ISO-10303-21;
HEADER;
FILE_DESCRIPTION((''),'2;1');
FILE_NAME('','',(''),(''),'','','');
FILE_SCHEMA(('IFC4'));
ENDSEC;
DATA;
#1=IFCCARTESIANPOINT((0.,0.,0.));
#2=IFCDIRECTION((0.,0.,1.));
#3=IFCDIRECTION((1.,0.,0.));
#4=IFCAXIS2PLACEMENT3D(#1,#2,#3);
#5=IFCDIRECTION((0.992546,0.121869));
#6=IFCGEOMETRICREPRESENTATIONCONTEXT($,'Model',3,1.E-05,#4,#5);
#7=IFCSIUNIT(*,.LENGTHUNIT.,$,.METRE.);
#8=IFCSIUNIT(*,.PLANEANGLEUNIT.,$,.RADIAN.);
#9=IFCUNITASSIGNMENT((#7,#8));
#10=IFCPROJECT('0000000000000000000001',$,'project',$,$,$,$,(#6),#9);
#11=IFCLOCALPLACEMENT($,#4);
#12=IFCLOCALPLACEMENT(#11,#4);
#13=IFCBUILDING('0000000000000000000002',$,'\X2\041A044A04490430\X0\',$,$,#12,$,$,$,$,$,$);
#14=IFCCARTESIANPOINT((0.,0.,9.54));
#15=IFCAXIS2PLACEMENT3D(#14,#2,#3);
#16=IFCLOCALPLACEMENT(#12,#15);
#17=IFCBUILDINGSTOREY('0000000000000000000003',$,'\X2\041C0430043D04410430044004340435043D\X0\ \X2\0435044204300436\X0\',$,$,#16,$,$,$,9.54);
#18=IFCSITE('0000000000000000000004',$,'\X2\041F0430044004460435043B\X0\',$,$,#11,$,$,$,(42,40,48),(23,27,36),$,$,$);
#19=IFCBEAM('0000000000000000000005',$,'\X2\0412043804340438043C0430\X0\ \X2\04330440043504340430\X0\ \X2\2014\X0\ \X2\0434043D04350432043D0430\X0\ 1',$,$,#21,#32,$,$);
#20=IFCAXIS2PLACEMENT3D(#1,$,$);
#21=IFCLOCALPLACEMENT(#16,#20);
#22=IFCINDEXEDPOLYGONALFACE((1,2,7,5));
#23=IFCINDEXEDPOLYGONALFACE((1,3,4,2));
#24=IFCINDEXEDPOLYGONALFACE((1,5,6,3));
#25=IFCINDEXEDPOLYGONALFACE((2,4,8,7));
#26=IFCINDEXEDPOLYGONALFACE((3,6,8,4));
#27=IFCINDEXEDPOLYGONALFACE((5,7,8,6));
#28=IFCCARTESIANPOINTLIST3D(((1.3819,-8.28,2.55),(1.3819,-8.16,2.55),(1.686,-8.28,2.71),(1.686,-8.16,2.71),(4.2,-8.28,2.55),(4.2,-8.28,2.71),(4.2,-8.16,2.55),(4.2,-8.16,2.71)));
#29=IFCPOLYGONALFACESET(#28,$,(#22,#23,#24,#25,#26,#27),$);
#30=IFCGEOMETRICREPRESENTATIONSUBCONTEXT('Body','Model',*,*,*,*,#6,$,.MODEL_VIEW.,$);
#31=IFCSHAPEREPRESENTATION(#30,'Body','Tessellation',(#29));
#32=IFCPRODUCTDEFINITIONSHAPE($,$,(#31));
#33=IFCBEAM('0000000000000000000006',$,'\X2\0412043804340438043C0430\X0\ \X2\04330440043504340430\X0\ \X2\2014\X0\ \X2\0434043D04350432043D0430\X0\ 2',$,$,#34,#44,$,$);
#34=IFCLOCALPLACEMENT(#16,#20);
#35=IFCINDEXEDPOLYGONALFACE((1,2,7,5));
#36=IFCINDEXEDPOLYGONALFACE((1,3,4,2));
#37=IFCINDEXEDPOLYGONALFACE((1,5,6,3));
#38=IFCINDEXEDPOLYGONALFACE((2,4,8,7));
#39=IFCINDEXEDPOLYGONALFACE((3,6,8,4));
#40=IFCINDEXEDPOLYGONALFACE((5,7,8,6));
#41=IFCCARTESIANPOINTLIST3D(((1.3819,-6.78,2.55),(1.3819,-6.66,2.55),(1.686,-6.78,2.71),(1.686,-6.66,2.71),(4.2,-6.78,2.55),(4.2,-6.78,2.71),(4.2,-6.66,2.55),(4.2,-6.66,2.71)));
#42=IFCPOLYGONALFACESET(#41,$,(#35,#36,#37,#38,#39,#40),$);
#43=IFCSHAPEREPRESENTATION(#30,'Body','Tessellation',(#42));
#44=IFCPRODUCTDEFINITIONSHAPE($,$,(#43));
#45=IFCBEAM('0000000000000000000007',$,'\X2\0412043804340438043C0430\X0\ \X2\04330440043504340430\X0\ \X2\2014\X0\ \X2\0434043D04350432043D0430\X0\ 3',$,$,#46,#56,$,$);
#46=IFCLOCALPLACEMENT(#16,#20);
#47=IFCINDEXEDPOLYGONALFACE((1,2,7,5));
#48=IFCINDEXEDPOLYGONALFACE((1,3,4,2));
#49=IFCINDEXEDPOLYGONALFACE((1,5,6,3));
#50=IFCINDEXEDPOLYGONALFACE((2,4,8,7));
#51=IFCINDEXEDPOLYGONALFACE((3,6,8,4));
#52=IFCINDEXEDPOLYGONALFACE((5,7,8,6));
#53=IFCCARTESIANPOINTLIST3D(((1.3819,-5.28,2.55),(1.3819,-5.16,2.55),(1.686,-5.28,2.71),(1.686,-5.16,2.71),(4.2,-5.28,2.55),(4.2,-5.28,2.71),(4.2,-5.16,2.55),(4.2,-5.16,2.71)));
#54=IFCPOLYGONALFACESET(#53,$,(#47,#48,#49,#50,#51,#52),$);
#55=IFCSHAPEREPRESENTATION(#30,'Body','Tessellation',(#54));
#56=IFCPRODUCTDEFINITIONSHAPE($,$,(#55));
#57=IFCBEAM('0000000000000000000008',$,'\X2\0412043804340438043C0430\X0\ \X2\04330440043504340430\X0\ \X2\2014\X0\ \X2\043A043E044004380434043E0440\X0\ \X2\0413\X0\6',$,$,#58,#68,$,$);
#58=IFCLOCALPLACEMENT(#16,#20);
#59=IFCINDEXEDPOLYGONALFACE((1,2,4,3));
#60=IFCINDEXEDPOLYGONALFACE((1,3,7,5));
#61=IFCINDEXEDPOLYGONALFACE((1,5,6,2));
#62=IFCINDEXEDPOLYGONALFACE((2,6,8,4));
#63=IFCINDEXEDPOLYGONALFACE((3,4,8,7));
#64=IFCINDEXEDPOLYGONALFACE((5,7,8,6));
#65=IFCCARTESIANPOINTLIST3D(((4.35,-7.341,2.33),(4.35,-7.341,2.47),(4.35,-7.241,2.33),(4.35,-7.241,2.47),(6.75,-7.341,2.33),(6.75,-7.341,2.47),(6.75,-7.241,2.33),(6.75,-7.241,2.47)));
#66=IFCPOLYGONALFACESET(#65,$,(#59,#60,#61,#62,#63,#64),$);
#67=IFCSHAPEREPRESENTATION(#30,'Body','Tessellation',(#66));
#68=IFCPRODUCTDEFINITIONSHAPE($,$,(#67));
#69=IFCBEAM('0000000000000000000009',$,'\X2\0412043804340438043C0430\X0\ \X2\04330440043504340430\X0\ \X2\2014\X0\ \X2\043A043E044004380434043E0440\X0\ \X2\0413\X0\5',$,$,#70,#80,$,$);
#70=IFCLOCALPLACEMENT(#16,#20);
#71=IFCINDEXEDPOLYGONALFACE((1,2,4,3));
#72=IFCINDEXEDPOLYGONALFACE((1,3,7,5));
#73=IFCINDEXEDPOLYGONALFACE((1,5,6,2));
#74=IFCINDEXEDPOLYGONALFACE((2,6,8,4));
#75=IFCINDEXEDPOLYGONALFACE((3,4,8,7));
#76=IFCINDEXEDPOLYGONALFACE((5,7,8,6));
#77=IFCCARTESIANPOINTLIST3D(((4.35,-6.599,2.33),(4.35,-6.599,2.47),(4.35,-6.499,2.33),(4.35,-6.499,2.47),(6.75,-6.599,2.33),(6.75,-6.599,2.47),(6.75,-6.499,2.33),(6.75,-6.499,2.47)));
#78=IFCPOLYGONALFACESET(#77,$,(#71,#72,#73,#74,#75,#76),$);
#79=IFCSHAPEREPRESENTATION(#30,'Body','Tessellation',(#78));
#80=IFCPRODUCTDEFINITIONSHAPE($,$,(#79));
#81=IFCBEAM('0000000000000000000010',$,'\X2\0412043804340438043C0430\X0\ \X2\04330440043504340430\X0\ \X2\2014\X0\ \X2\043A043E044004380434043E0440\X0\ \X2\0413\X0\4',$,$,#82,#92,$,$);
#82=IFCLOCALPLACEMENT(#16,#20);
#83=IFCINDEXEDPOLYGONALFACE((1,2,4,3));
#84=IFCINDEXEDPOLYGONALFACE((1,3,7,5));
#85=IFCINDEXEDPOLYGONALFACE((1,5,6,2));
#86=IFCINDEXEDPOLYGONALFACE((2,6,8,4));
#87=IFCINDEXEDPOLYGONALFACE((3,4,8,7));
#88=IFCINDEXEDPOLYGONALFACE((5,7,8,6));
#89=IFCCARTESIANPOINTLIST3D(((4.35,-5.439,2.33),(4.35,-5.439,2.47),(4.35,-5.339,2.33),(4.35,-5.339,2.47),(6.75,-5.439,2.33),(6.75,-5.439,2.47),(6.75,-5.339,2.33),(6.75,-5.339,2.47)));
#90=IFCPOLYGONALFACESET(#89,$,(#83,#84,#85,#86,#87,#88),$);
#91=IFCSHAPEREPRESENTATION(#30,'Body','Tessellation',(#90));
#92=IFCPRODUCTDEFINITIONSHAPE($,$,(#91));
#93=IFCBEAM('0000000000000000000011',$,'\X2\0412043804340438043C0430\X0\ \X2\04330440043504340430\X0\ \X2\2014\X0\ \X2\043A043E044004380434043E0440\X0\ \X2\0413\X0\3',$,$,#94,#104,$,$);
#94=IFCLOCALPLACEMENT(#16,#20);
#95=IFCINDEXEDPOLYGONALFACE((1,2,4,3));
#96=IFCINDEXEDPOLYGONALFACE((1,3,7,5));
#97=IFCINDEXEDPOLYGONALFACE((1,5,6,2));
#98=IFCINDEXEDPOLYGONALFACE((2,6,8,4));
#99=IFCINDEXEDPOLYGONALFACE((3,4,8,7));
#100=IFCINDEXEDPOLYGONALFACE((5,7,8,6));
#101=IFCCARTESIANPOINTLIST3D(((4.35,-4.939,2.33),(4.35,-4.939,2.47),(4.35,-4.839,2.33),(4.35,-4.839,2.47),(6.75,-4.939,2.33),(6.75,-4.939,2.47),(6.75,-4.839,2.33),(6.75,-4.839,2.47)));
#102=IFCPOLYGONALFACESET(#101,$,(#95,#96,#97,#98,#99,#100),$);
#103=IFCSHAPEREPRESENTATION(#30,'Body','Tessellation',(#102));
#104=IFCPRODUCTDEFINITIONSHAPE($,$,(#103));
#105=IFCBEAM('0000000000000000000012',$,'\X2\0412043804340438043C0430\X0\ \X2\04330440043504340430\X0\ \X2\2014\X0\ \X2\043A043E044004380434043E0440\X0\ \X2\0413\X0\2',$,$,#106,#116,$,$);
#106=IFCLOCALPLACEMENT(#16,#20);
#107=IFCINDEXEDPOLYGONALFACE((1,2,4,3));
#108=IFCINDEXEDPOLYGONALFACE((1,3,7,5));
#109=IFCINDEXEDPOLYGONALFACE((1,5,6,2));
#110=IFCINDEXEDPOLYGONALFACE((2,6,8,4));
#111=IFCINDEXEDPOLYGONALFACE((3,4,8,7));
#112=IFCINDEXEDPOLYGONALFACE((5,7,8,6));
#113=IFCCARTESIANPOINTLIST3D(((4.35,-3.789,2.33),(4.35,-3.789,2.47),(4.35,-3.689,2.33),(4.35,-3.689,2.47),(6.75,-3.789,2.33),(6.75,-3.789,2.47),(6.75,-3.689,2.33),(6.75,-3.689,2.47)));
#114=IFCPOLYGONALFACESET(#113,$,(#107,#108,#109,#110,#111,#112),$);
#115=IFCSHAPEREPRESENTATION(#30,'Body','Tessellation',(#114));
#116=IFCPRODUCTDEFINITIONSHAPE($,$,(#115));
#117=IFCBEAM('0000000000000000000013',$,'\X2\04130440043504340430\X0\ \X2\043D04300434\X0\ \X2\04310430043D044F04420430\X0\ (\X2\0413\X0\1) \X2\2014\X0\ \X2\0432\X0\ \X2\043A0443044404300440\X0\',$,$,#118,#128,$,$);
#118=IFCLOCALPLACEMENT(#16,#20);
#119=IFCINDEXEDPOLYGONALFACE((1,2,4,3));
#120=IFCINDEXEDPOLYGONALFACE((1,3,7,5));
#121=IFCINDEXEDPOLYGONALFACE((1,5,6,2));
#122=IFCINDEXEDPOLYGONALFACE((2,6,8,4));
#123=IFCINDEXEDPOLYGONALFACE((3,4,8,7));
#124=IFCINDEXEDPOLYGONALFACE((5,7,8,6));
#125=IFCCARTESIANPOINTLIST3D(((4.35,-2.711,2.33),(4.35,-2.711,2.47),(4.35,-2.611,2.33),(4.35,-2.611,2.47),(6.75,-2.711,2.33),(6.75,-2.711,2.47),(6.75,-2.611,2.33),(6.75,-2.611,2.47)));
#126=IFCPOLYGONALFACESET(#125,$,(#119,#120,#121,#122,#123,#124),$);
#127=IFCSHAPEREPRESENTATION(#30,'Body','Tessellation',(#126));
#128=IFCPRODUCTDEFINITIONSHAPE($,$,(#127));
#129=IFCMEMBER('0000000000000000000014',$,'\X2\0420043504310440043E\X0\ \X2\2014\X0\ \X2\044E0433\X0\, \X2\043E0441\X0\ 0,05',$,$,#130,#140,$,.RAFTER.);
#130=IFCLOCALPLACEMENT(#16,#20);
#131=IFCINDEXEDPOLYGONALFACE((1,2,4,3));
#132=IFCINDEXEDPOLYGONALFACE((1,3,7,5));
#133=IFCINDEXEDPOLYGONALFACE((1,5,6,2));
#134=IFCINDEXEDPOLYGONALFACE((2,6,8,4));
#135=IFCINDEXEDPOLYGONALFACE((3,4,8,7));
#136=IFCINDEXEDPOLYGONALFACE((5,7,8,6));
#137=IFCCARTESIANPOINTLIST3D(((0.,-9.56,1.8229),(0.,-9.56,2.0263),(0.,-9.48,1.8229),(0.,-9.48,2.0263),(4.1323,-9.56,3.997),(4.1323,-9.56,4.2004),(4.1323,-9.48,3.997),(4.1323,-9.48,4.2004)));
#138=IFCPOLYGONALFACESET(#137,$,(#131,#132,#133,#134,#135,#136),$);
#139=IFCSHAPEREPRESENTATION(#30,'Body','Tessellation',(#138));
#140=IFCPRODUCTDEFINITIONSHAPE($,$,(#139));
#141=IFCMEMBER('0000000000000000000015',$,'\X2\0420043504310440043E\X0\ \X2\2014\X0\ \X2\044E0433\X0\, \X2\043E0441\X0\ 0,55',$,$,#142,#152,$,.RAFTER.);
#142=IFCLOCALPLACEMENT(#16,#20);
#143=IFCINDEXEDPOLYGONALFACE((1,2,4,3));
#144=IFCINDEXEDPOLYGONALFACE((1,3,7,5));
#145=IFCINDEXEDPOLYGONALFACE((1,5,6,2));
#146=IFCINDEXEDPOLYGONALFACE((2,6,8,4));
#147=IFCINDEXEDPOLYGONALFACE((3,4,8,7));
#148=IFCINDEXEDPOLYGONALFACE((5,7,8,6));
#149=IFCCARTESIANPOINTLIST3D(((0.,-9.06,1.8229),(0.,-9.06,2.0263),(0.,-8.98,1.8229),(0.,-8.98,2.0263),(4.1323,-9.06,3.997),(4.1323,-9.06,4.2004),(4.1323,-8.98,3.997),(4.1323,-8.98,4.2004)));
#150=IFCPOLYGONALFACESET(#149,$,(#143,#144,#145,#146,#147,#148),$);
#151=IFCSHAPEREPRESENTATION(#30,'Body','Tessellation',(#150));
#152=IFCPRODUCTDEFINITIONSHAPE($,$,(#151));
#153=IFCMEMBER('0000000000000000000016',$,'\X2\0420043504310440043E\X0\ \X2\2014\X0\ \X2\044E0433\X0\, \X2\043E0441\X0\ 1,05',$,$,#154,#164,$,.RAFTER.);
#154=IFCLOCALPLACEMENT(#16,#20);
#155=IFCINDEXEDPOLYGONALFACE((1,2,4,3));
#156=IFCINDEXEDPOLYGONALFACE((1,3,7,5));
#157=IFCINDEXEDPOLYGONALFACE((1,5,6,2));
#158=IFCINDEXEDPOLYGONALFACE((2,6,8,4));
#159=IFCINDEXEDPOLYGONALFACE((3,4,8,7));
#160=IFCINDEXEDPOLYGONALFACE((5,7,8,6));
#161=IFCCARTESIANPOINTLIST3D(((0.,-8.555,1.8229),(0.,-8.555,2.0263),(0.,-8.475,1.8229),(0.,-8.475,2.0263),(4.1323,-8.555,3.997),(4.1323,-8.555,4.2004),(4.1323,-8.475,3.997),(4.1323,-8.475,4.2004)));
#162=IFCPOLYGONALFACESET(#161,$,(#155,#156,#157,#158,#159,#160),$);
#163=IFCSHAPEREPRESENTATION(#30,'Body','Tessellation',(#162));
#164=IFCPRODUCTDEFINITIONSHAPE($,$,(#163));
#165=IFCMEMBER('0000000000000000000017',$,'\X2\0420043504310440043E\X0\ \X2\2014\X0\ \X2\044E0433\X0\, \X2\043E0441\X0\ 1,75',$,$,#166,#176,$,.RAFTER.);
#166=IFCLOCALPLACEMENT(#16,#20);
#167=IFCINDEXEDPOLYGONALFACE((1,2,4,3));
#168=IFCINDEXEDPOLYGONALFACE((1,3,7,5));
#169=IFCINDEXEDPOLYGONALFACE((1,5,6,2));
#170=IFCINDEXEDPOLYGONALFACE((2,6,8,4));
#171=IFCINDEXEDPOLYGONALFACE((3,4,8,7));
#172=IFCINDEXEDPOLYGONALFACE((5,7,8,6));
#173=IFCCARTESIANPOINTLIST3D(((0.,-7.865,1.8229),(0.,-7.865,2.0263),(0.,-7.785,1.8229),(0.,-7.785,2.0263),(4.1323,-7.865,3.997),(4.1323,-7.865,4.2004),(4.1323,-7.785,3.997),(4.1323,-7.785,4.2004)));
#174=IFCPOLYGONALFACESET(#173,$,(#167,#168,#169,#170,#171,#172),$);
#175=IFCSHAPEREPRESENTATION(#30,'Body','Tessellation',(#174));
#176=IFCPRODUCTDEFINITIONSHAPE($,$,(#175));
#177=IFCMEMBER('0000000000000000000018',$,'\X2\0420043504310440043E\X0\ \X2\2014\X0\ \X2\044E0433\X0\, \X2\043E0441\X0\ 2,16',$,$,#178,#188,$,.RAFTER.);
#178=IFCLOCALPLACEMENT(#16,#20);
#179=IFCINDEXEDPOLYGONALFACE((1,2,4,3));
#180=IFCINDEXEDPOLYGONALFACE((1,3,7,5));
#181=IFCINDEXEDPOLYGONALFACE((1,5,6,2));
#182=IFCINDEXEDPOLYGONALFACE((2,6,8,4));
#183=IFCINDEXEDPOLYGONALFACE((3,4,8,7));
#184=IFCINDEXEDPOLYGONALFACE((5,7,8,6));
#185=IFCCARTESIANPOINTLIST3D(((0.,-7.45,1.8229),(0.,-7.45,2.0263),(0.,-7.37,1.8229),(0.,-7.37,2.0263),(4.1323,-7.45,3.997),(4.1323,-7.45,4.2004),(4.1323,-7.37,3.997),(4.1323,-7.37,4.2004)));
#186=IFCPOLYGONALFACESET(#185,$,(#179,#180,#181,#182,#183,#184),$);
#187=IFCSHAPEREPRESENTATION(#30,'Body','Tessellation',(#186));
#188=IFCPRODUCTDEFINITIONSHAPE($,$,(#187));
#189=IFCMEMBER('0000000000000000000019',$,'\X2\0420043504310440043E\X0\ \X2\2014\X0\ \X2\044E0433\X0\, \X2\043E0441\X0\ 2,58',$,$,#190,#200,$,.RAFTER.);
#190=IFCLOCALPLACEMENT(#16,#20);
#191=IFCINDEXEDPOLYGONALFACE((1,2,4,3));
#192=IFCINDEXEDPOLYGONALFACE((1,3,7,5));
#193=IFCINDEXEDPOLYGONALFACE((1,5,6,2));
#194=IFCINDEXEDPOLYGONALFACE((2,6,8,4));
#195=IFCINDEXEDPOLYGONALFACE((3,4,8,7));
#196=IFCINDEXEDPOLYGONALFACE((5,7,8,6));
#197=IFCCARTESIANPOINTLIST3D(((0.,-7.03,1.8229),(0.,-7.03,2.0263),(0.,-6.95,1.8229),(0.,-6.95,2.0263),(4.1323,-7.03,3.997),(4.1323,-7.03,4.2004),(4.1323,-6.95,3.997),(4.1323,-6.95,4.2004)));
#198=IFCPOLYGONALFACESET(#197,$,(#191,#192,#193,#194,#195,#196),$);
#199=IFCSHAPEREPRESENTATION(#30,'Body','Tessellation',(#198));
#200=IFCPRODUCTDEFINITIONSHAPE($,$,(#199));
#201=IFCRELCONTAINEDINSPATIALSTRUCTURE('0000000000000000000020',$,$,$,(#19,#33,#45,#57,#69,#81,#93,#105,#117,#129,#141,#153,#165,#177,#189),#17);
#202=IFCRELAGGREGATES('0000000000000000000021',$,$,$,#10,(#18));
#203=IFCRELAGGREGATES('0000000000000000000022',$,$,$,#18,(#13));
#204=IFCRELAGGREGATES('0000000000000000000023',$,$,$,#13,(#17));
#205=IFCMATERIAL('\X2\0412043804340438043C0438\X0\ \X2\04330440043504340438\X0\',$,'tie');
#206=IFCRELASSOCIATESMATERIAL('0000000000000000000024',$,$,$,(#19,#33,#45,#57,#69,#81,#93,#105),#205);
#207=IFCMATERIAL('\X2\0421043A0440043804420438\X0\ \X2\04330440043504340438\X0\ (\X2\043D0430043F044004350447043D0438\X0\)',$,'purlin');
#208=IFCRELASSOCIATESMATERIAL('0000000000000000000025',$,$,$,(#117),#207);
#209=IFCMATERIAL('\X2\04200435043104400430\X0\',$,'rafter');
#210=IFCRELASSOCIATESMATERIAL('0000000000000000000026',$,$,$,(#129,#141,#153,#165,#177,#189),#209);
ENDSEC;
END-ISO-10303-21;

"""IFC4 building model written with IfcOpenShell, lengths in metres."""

from ifc_helpers import new_model, si_unit, direction, frame, origin_with_axes, place, context, subcontext, project, spatial, polyline, outline, extrude, material, element, save


model = new_model("IFC4")

# Units and contexts
model_context = context("Model", 3, precision=1e-05, world=origin_with_axes(), true_north=direction((0.992546, 0.121869)))
body_context = subcontext(model_context, "Body", "Model", "MODEL_VIEW")
ifc_project = project(units=[si_unit("LENGTHUNIT", "METRE"), si_unit("PLANEANGLEUNIT", "RADIAN")], contexts=[model_context])

# Site, building, storey
site_placement = place(None, origin_with_axes())
site = spatial("IfcSite", under=ifc_project, at=site_placement, Name="Парцел", RefLatitude=(42, 40, 48), RefLongitude=(23, 27, 36))
building_placement = place(site_placement, origin_with_axes())
building = spatial("IfcBuilding", under=site, at=building_placement, Name="Къща")
storey_placement = place(building_placement, frame((0.0, 0.0, 9.54), z_axis=(0.0, 0.0, 1.0), x_axis=(1.0, 0.0, 0.0)))
storey = spatial("IfcBuildingStorey", under=building, at=storey_placement, Name="Мансарден етаж", Elevation=9.54)

# Beams
ifc_material_1 = material(Name="Видими греди", Category="tie")
beam_1_placement = place(storey_placement, origin_with_axes())
element("IfcBeam", 1, at=beam_1_placement, inside=storey, material=ifc_material_1, Name="Видима греда — дневна 1", context=body_context, shape_type="SweptSolid", body=[
    extrude(outline(polyline([(1.3819, -2.55), (4.2, -2.55), (4.2, -2.71), (1.686, -2.71), (1.3819, -2.55)])), frame((0.0, -8.28, 0.0), z_axis=(0.0, 1.0, 0.0), x_axis=(1.0, 0.0, 0.0)), (0.0, 0.0, 1.0), 0.12),
])
beam_2_placement = place(storey_placement, origin_with_axes())
element("IfcBeam", 2, at=beam_2_placement, inside=storey, material=ifc_material_1, Name="Видима греда — дневна 2", context=body_context, shape_type="SweptSolid", body=[
    extrude(outline(polyline([(1.3819, -2.55), (4.2, -2.55), (4.2, -2.71), (1.686, -2.71), (1.3819, -2.55)])), frame((0.0, -6.78, 0.0), z_axis=(0.0, 1.0, 0.0), x_axis=(1.0, 0.0, 0.0)), (0.0, 0.0, 1.0), 0.12),
])
beam_3_placement = place(storey_placement, origin_with_axes())
element("IfcBeam", 3, at=beam_3_placement, inside=storey, material=ifc_material_1, Name="Видима греда — дневна 3", context=body_context, shape_type="SweptSolid", body=[
    extrude(outline(polyline([(1.3819, -2.55), (4.2, -2.55), (4.2, -2.71), (1.686, -2.71), (1.3819, -2.55)])), frame((0.0, -5.28, 0.0), z_axis=(0.0, 1.0, 0.0), x_axis=(1.0, 0.0, 0.0)), (0.0, 0.0, 1.0), 0.12),
])
beam_4_placement = place(storey_placement, origin_with_axes())
element("IfcBeam", 4, at=beam_4_placement, inside=storey, material=ifc_material_1, Name="Видима греда — коридор Г6", context=body_context, shape_type="SweptSolid", body=[
    extrude(outline(polyline([(4.35, -2.33), (6.75, -2.33), (6.75, -2.47), (4.35, -2.47), (4.35, -2.33)])), frame((0.0, -7.341, 0.0), z_axis=(0.0, 1.0, 0.0), x_axis=(1.0, 0.0, 0.0)), (0.0, 0.0, 1.0), 0.1),
])
beam_5_placement = place(storey_placement, origin_with_axes())
element("IfcBeam", 5, at=beam_5_placement, inside=storey, material=ifc_material_1, Name="Видима греда — коридор Г5", context=body_context, shape_type="SweptSolid", body=[
    extrude(outline(polyline([(4.35, -2.33), (6.75, -2.33), (6.75, -2.47), (4.35, -2.47), (4.35, -2.33)])), frame((0.0, -6.599, 0.0), z_axis=(0.0, 1.0, 0.0), x_axis=(1.0, 0.0, 0.0)), (0.0, 0.0, 1.0), 0.1),
])
beam_6_placement = place(storey_placement, origin_with_axes())
element("IfcBeam", 6, at=beam_6_placement, inside=storey, material=ifc_material_1, Name="Видима греда — коридор Г4", context=body_context, shape_type="SweptSolid", body=[
    extrude(outline(polyline([(4.35, -2.33), (6.75, -2.33), (6.75, -2.47), (4.35, -2.47), (4.35, -2.33)])), frame((0.0, -5.439, 0.0), z_axis=(0.0, 1.0, 0.0), x_axis=(1.0, 0.0, 0.0)), (0.0, 0.0, 1.0), 0.1),
])
beam_7_placement = place(storey_placement, origin_with_axes())
element("IfcBeam", 7, at=beam_7_placement, inside=storey, material=ifc_material_1, Name="Видима греда — коридор Г3", context=body_context, shape_type="SweptSolid", body=[
    extrude(outline(polyline([(4.35, -2.33), (6.75, -2.33), (6.75, -2.47), (4.35, -2.47), (4.35, -2.33)])), frame((0.0, -4.939, 0.0), z_axis=(0.0, 1.0, 0.0), x_axis=(1.0, 0.0, 0.0)), (0.0, 0.0, 1.0), 0.1),
])
beam_8_placement = place(storey_placement, origin_with_axes())
element("IfcBeam", 8, at=beam_8_placement, inside=storey, material=ifc_material_1, Name="Видима греда — коридор Г2", context=body_context, shape_type="SweptSolid", body=[
    extrude(outline(polyline([(4.35, -2.33), (6.75, -2.33), (6.75, -2.47), (4.35, -2.47), (4.35, -2.33)])), frame((0.0, -3.789, 0.0), z_axis=(0.0, 1.0, 0.0), x_axis=(1.0, 0.0, 0.0)), (0.0, 0.0, 1.0), 0.1),
])
ifc_material_2 = material(Name="Скрити греди (напречни)", Category="purlin")
beam_9_placement = place(storey_placement, origin_with_axes())
element("IfcBeam", 9, at=beam_9_placement, inside=storey, material=ifc_material_2, Name="Греда над банята (Г1) — в куфар", context=body_context, shape_type="SweptSolid", body=[
    extrude(outline(polyline([(4.35, -2.33), (6.75, -2.33), (6.75, -2.47), (4.35, -2.47), (4.35, -2.33)])), frame((0.0, -2.711, 0.0), z_axis=(0.0, 1.0, 0.0), x_axis=(1.0, 0.0, 0.0)), (0.0, 0.0, 1.0), 0.1),
])

# Members
ifc_material_3 = material(Name="Ребра", Category="rafter")
member_1_placement = place(storey_placement, origin_with_axes())
element("IfcMember", 10, at=member_1_placement, inside=storey, material=ifc_material_3, Name="Ребро — юг, ос 0,05", PredefinedType="RAFTER", context=body_context, shape_type="SweptSolid", body=[
    extrude(outline(polyline([(0.0, -1.8229), (4.1323, -3.997), (4.1323, -4.2004), (0.0, -2.0263), (0.0, -1.8229)])), frame((0.0, -9.56, 0.0), z_axis=(0.0, 1.0, 0.0), x_axis=(1.0, 0.0, 0.0)), (0.0, 0.0, 1.0), 0.08),
])
member_2_placement = place(storey_placement, origin_with_axes())
element("IfcMember", 11, at=member_2_placement, inside=storey, material=ifc_material_3, Name="Ребро — юг, ос 0,55", PredefinedType="RAFTER", context=body_context, shape_type="SweptSolid", body=[
    extrude(outline(polyline([(0.0, -1.8229), (4.1323, -3.997), (4.1323, -4.2004), (0.0, -2.0263), (0.0, -1.8229)])), frame((0.0, -9.06, 0.0), z_axis=(0.0, 1.0, 0.0), x_axis=(1.0, 0.0, 0.0)), (0.0, 0.0, 1.0), 0.08),
])
member_3_placement = place(storey_placement, origin_with_axes())
element("IfcMember", 12, at=member_3_placement, inside=storey, material=ifc_material_3, Name="Ребро — юг, ос 1,05", PredefinedType="RAFTER", context=body_context, shape_type="SweptSolid", body=[
    extrude(outline(polyline([(0.0, -1.8229), (4.1323, -3.997), (4.1323, -4.2004), (0.0, -2.0263), (0.0, -1.8229)])), frame((0.0, -8.555, 0.0), z_axis=(0.0, 1.0, 0.0), x_axis=(1.0, 0.0, 0.0)), (0.0, 0.0, 1.0), 0.08),
])
member_4_placement = place(storey_placement, origin_with_axes())
element("IfcMember", 13, at=member_4_placement, inside=storey, material=ifc_material_3, Name="Ребро — юг, ос 1,75", PredefinedType="RAFTER", context=body_context, shape_type="SweptSolid", body=[
    extrude(outline(polyline([(0.0, -1.8229), (4.1323, -3.997), (4.1323, -4.2004), (0.0, -2.0263), (0.0, -1.8229)])), frame((0.0, -7.865, 0.0), z_axis=(0.0, 1.0, 0.0), x_axis=(1.0, 0.0, 0.0)), (0.0, 0.0, 1.0), 0.08),
])
member_5_placement = place(storey_placement, origin_with_axes())
element("IfcMember", 14, at=member_5_placement, inside=storey, material=ifc_material_3, Name="Ребро — юг, ос 2,16", PredefinedType="RAFTER", context=body_context, shape_type="SweptSolid", body=[
    extrude(outline(polyline([(0.0, -1.8229), (4.1323, -3.997), (4.1323, -4.2004), (0.0, -2.0263), (0.0, -1.8229)])), frame((0.0, -7.45, 0.0), z_axis=(0.0, 1.0, 0.0), x_axis=(1.0, 0.0, 0.0)), (0.0, 0.0, 1.0), 0.08),
])
member_6_placement = place(storey_placement, origin_with_axes())
element("IfcMember", 15, at=member_6_placement, inside=storey, material=ifc_material_3, Name="Ребро — юг, ос 2,58", PredefinedType="RAFTER", context=body_context, shape_type="SweptSolid", body=[
    extrude(outline(polyline([(0.0, -1.8229), (4.1323, -3.997), (4.1323, -4.2004), (0.0, -2.0263), (0.0, -1.8229)])), frame((0.0, -7.03, 0.0), z_axis=(0.0, 1.0, 0.0), x_axis=(1.0, 0.0, 0.0)), (0.0, 0.0, 1.0), 0.08),
])

save(model, "model.ifc")
